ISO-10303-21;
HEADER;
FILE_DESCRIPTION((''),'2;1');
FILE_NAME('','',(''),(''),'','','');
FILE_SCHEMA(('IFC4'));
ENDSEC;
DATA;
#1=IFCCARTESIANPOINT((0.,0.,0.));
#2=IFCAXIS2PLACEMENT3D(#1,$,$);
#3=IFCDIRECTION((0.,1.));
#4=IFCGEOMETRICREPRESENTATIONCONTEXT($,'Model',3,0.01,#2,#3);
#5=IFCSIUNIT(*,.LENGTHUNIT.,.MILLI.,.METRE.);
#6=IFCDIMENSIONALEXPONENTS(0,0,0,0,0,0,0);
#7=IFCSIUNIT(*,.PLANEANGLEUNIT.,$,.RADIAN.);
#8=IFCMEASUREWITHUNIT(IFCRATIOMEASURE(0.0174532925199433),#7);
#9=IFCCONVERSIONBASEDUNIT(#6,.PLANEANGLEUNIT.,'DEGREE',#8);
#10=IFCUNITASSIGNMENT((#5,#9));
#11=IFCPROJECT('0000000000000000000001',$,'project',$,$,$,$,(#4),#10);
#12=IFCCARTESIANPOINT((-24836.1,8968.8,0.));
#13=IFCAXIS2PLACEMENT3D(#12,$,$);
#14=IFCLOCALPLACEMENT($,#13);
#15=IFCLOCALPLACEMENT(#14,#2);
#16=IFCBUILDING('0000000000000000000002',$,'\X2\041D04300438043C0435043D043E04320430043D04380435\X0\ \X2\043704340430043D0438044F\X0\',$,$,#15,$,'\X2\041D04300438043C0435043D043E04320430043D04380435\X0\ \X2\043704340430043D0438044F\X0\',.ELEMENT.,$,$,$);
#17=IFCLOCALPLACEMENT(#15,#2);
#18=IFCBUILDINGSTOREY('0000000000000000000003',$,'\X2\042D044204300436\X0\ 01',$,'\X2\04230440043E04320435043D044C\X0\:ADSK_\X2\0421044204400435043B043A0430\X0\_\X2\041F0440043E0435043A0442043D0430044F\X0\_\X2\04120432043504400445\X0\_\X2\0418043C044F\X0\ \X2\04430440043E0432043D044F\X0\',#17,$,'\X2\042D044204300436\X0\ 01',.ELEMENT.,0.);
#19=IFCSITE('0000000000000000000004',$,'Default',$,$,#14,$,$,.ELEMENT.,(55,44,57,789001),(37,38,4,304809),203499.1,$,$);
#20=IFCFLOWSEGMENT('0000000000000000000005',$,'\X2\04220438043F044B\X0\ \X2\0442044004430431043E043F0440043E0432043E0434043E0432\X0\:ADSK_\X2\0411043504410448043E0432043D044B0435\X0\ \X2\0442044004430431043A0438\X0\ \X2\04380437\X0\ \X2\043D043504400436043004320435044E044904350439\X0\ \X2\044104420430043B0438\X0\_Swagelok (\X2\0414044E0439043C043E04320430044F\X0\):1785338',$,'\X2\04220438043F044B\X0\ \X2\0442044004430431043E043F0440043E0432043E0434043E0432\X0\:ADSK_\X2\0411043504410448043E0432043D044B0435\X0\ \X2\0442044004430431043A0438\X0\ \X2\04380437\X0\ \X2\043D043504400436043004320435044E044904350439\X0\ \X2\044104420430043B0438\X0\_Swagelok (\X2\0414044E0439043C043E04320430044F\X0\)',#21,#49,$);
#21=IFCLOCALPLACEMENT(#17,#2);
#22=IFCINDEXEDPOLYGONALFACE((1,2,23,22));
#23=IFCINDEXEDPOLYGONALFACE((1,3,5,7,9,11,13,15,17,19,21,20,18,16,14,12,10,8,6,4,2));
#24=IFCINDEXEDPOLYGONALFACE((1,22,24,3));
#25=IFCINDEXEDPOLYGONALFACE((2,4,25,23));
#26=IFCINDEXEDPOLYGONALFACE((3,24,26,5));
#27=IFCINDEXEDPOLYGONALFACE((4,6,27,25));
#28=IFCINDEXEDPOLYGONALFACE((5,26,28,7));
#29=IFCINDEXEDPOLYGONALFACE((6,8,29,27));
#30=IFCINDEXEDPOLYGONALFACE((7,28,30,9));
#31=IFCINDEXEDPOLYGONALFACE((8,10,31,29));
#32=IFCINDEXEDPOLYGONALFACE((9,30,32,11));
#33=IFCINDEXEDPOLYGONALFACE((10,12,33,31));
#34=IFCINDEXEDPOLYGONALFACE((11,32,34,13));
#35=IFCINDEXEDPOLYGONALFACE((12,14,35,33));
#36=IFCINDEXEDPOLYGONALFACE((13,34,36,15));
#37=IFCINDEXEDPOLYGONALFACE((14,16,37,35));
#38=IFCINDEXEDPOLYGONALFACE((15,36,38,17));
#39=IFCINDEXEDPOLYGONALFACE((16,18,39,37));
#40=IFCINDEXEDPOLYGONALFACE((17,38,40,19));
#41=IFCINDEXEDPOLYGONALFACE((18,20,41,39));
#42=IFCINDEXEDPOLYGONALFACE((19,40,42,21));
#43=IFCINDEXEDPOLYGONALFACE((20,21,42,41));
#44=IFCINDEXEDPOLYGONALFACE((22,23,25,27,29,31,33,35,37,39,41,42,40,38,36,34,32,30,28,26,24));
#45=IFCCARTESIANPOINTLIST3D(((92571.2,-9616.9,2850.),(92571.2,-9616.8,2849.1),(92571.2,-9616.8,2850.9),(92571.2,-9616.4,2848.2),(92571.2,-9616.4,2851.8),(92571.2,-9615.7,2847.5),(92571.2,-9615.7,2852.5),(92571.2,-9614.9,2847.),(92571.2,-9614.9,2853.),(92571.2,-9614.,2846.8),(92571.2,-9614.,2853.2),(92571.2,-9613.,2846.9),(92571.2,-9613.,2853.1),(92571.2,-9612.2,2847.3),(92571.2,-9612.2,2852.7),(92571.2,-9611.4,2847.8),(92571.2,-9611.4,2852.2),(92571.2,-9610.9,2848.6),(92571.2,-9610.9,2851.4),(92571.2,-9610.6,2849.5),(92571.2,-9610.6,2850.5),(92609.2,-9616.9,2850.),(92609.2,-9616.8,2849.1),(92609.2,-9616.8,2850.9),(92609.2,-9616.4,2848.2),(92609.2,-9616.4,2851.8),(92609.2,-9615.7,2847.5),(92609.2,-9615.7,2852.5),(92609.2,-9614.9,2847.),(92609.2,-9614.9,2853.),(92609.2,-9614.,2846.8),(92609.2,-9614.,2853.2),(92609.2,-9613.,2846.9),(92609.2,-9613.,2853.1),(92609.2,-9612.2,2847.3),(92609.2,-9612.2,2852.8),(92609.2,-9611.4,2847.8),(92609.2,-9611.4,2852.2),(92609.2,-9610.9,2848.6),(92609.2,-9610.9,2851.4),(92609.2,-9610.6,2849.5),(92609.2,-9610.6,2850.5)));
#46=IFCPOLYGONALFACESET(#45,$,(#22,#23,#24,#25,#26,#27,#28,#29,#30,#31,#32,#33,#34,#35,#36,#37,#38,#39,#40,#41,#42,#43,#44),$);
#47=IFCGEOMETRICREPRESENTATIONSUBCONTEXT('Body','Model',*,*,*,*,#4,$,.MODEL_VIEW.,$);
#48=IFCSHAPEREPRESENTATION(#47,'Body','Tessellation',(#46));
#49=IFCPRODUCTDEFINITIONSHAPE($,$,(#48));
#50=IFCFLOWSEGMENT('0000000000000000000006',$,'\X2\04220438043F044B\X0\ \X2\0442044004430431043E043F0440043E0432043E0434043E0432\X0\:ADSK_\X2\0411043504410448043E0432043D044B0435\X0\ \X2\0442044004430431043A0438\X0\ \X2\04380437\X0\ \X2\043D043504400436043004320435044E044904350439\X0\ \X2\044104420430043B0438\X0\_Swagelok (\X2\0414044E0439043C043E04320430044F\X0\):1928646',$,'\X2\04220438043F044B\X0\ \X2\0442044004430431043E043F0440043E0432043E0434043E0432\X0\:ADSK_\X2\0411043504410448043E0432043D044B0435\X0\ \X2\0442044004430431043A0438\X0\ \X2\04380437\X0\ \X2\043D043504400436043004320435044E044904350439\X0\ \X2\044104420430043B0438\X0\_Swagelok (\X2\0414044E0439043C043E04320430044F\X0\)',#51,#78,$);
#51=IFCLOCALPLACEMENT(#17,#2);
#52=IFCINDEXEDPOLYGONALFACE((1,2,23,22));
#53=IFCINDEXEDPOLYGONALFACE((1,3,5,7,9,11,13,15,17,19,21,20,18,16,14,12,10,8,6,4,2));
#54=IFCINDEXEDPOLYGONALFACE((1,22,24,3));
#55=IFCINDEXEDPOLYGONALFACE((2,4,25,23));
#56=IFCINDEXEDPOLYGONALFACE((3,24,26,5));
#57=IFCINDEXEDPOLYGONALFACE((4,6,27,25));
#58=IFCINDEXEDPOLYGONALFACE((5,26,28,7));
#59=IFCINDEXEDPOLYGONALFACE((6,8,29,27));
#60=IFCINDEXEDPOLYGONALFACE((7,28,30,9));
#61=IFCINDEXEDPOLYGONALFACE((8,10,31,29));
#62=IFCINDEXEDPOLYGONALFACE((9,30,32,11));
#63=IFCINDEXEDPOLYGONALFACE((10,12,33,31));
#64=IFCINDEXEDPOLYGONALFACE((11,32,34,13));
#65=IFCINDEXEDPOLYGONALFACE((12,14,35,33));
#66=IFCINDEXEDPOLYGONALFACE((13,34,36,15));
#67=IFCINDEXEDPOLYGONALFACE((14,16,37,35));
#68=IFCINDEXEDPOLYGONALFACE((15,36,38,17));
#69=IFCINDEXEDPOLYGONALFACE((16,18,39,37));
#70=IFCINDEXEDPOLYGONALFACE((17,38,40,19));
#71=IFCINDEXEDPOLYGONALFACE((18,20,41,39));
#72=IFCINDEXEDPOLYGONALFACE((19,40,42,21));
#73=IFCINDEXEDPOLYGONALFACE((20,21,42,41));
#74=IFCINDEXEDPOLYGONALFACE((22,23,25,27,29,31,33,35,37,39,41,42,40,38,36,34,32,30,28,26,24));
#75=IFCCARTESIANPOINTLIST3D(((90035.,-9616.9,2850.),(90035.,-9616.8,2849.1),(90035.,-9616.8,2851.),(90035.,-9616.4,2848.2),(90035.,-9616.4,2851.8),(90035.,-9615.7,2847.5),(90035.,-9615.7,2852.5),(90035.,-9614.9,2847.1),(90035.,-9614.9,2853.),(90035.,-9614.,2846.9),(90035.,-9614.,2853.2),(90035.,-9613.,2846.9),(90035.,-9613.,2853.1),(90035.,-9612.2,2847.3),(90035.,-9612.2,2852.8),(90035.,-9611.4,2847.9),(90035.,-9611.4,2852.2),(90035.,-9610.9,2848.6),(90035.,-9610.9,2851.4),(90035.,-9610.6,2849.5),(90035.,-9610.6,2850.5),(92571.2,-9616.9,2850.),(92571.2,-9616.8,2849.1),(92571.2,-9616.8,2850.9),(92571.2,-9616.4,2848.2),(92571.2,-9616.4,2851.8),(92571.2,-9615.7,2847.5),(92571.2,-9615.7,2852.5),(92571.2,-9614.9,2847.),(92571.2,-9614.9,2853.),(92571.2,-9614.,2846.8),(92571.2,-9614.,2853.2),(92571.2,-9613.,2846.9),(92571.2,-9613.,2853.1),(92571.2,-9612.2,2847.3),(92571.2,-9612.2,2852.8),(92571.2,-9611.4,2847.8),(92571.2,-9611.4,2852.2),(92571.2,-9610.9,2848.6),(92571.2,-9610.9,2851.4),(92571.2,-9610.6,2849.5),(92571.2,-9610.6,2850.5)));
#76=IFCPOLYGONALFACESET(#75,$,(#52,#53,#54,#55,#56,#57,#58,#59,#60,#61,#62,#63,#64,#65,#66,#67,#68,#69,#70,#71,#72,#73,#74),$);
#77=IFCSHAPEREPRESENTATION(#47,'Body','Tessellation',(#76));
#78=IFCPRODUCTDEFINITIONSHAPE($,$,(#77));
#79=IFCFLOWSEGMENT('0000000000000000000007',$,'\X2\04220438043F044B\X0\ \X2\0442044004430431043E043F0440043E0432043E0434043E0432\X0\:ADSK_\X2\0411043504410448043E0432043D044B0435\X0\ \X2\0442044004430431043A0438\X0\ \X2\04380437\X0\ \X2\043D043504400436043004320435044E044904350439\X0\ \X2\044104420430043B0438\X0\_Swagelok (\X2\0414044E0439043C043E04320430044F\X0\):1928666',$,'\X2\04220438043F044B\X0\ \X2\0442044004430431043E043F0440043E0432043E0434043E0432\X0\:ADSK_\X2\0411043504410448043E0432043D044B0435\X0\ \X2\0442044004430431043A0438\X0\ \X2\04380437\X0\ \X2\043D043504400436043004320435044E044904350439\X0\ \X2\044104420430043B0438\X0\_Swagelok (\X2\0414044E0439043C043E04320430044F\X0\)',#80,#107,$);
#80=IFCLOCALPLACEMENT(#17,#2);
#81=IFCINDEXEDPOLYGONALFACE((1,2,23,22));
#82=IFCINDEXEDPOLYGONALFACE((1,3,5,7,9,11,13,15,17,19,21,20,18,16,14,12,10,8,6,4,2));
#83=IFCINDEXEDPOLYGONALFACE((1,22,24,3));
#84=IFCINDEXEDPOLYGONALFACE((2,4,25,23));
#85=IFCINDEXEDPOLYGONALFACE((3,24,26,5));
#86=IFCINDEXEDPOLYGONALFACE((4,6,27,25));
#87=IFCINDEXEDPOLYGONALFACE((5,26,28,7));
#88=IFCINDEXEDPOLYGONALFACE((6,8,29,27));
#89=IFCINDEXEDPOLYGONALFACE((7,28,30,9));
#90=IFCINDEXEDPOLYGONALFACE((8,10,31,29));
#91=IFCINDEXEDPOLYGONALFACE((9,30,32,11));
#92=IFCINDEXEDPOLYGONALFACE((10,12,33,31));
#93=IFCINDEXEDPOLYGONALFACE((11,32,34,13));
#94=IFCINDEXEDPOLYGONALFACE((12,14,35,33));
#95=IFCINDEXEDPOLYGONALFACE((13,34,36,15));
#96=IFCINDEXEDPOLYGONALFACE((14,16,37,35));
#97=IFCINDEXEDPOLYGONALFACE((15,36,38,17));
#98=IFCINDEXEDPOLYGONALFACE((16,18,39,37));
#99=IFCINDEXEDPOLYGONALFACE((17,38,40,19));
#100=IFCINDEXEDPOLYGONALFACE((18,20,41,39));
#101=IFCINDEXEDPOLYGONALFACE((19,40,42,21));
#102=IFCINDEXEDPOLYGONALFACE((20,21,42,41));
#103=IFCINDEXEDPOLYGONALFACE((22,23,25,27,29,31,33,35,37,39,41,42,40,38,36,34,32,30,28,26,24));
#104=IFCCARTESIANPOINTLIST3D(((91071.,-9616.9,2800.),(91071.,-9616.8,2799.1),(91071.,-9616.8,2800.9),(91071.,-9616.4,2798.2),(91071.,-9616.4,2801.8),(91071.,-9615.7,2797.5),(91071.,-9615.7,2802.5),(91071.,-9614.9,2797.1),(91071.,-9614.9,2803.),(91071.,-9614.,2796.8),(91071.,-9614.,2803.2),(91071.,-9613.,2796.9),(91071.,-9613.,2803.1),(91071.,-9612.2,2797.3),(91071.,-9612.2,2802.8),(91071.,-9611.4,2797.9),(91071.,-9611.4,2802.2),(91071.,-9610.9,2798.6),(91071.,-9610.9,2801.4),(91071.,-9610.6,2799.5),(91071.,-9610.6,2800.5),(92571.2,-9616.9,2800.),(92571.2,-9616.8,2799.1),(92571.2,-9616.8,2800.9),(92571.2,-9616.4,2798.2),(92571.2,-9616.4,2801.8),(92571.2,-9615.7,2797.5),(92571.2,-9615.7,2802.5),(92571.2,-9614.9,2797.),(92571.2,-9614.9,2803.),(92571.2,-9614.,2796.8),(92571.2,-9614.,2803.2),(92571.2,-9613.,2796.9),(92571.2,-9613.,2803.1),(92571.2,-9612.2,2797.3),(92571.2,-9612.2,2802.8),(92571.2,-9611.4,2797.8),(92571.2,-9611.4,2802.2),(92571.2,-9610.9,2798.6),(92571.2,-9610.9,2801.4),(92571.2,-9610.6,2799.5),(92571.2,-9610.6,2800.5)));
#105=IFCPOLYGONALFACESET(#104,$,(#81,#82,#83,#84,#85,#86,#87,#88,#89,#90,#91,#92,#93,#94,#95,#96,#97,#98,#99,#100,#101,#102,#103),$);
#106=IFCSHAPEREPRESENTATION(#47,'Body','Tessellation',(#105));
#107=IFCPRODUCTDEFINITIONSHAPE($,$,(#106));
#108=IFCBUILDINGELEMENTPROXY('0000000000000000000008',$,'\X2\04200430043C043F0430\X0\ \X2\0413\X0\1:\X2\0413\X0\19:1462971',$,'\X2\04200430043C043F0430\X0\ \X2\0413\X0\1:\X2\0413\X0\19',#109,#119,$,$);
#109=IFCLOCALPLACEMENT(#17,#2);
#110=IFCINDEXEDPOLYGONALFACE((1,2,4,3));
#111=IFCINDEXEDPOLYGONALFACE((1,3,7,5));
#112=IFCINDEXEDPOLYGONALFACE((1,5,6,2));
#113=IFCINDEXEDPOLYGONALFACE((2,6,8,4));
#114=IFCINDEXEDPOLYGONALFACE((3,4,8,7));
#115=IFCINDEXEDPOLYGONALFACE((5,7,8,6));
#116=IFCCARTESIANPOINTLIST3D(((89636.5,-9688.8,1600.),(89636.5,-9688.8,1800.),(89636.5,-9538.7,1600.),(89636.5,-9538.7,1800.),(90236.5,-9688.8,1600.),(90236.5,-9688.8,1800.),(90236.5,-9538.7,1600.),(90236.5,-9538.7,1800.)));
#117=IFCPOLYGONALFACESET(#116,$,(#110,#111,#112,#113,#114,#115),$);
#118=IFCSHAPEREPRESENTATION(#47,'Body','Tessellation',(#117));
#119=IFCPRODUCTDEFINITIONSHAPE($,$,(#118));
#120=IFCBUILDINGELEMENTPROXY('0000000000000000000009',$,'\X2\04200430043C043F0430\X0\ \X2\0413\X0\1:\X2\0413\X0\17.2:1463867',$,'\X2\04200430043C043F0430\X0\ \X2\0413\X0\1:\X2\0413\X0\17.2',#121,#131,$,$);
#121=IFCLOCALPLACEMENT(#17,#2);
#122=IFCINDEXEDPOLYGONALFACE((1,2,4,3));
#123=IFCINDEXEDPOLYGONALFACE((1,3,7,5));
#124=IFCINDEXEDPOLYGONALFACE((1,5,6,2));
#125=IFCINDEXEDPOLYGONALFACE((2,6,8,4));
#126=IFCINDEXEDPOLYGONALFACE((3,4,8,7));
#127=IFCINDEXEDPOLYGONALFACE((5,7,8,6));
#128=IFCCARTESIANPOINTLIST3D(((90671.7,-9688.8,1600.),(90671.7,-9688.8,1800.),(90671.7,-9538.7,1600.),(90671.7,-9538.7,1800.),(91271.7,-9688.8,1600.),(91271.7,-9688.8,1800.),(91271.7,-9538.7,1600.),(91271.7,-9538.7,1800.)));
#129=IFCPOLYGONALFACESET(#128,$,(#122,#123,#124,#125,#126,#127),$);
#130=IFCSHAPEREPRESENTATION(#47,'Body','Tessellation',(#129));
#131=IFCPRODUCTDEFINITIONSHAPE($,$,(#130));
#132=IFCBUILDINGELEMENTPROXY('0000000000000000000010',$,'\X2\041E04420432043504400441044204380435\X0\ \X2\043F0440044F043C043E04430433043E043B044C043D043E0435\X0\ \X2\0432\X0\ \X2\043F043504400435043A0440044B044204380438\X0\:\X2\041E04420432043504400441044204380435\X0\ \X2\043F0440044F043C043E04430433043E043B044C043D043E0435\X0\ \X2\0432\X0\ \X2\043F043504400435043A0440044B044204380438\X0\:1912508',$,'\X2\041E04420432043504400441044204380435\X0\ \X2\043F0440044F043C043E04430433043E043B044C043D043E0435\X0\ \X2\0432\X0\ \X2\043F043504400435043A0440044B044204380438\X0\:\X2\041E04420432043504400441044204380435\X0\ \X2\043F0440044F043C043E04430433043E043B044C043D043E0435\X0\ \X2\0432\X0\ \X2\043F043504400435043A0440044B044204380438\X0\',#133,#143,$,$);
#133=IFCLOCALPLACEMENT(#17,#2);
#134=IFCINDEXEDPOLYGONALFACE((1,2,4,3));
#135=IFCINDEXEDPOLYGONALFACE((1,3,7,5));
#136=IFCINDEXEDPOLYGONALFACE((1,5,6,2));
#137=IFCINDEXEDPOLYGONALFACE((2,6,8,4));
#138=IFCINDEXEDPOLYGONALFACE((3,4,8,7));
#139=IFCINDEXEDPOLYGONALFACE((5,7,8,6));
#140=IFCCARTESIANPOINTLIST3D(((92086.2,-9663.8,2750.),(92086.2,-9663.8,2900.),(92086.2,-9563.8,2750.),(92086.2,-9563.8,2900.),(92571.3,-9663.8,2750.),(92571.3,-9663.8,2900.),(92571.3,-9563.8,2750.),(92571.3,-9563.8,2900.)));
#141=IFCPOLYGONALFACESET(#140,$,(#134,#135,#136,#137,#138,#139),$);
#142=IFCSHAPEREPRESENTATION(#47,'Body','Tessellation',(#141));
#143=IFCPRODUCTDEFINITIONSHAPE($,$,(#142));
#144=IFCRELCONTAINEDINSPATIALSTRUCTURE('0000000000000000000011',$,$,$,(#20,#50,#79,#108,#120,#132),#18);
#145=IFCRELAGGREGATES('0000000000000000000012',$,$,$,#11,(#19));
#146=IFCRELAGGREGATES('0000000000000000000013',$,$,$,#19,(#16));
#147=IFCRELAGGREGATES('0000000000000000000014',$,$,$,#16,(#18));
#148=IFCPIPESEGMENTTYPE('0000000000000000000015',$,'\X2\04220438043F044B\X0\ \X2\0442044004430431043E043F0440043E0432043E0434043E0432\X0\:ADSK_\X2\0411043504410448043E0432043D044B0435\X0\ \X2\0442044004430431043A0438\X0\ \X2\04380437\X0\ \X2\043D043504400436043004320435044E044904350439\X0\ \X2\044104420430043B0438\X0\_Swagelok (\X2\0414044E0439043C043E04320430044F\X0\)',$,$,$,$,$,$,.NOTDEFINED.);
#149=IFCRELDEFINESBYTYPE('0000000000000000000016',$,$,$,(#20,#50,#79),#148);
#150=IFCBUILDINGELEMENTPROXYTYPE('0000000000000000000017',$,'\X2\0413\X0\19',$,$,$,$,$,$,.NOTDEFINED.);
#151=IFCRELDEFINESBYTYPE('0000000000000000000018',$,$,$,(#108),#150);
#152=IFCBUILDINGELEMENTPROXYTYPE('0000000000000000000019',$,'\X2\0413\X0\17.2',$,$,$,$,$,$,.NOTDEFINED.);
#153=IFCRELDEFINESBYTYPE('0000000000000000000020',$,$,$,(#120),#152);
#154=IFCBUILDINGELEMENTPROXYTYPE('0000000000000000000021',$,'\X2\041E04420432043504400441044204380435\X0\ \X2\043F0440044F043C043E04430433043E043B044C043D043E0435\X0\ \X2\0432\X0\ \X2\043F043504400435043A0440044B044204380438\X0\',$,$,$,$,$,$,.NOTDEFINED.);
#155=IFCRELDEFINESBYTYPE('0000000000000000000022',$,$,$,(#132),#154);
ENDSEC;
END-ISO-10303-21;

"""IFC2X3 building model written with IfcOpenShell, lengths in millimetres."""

from ifc_helpers import new_model, entity, si_unit, converted_unit, direction, frame, origin, origin_2d_with_axis, place, context, subcontext, project, spatial, rectangle, circle, extrude, type_object, element, save


model = new_model("IFC2X3")

# Units and contexts
model_context = context("Model", 3, precision=0.01, world=origin(), true_north=direction((0.0, 1.0)))
body_context = subcontext(model_context, "Body", "Model", "MODEL_VIEW")
ifc_project = project(units=[si_unit("LENGTHUNIT", "METRE", prefix="MILLI"), converted_unit("PLANEANGLEUNIT", "DEGREE", entity("IfcRatioMeasure", 0.0174532925199433), si_unit("PLANEANGLEUNIT", "RADIAN"), dimensions=[0, 0, 0, 0, 0, 0, 0])], contexts=[model_context])

# Site, building, storey
site_placement = place(None, frame((-24836.1, 8968.8, 0.0)))
site = spatial("IfcSite", under=ifc_project, at=site_placement, Name="Default", CompositionType="ELEMENT", RefLatitude=(55, 44, 57, 789001), RefLongitude=(37, 38, 4, 304809), RefElevation=203499.1)
building_placement = place(site_placement, origin())
building = spatial("IfcBuilding", under=site, at=building_placement, Name="Наименование здания", LongName="Наименование здания", CompositionType="ELEMENT")
storey_placement = place(building_placement, origin())
storey = spatial("IfcBuildingStorey", under=building, at=storey_placement, Name="Этаж 01", ObjectType="Уровень:ADSK_Стрелка_Проектная_Вверх_Имя уровня", LongName="Этаж 01", CompositionType="ELEMENT", Elevation=0.0)

# Flow segments
pipe_segment_type_1 = type_object("IfcPipeSegmentType", Name="Типы трубопроводов:ADSK_Бесшовные трубки из нержавеющей стали_Swagelok (Дюймовая)", PredefinedType="NOTDEFINED")
flow_segment_1_placement = place(storey_placement, frame((92571.2, -9618.5, 2845.2)))
element("IfcFlowSegment", 1, at=flow_segment_1_placement, inside=storey, type_object=pipe_segment_type_1, Name="Типы трубопроводов:ADSK_Бесшовные трубки из нержавеющей стали_Swagelok (Дюймовая):1785338", ObjectType="Типы трубопроводов:ADSK_Бесшовные трубки из нержавеющей стали_Swagelok (Дюймовая)", context=body_context, shape_type="SweptSolid", body=[
    extrude(circle(Radius=3.2, at=origin_2d_with_axis()), frame((0.0, 4.8, 4.8), z_axis=(1.0, 0.0, 0.000087), x_axis=(0.0, -1.0, 0.0)), (0.0, 0.0, 1.0), 38.0),
])
flow_segment_2_placement = place(storey_placement, frame((90035.0, -9618.5, 2845.2)))
element("IfcFlowSegment", 2, at=flow_segment_2_placement, inside=storey, type_object=pipe_segment_type_1, Name="Типы трубопроводов:ADSK_Бесшовные трубки из нержавеющей стали_Swagelok (Дюймовая):1928646", ObjectType="Типы трубопроводов:ADSK_Бесшовные трубки из нержавеющей стали_Swagelok (Дюймовая)", context=body_context, shape_type="SweptSolid", body=[
    extrude(circle(Radius=3.2, at=origin_2d_with_axis()), frame((0.0, 4.8, 4.8), z_axis=(1.0, 0.0, -0.000006), x_axis=(0.0, -1.0, 0.0)), (0.0, 0.0, 1.0), 2536.2),
])
flow_segment_3_placement = place(storey_placement, frame((91071.0, -9618.5, 2795.2)))
element("IfcFlowSegment", 3, at=flow_segment_3_placement, inside=storey, type_object=pipe_segment_type_1, Name="Типы трубопроводов:ADSK_Бесшовные трубки из нержавеющей стали_Swagelok (Дюймовая):1928666", ObjectType="Типы трубопроводов:ADSK_Бесшовные трубки из нержавеющей стали_Swagelok (Дюймовая)", context=body_context, shape_type="SweptSolid", body=[
    extrude(circle(Radius=3.2, at=origin_2d_with_axis()), frame((0.0, 4.8, 4.8), z_axis=(1.0, 0.0, -0.000006), x_axis=(0.0, -1.0, 0.0)), (0.0, 0.0, 1.0), 1500.3),
])

# Building element proxies
building_element_proxy_type_1 = type_object("IfcBuildingElementProxyType", Name="Г19", PredefinedType="NOTDEFINED")
proxy_1_placement = place(storey_placement, frame((89636.5, -9688.8, 1600.0)))
element("IfcBuildingElementProxy", 4, at=proxy_1_placement, inside=storey, type_object=building_element_proxy_type_1, Name="Рампа Г1:Г19:1462971", ObjectType="Рампа Г1:Г19", context=body_context, shape_type="SweptSolid", body=[
    extrude(rectangle(XDim=150.0, YDim=600.0, at=origin_2d_with_axis()), frame((300.0, 75.0, 0.0), z_axis=(0.0, 0.0, 1.0), x_axis=(0.0, 1.0, 0.0)), (0.0, 0.0, 1.0), 200.0),
])
building_element_proxy_type_2 = type_object("IfcBuildingElementProxyType", Name="Г17.2", PredefinedType="NOTDEFINED")
proxy_2_placement = place(storey_placement, frame((90671.7, -9688.8, 1600.0)))
element("IfcBuildingElementProxy", 5, at=proxy_2_placement, inside=storey, type_object=building_element_proxy_type_2, Name="Рампа Г1:Г17.2:1463867", ObjectType="Рампа Г1:Г17.2", context=body_context, shape_type="SweptSolid", body=[
    extrude(rectangle(XDim=150.0, YDim=600.0, at=origin_2d_with_axis()), frame((300.0, 75.0, 0.0), z_axis=(0.0, 0.0, 1.0), x_axis=(0.0, 1.0, 0.0)), (0.0, 0.0, 1.0), 200.0),
])
building_element_proxy_type_3 = type_object("IfcBuildingElementProxyType", Name="Отверстие прямоугольное в перекрытии", PredefinedType="NOTDEFINED")
proxy_3_placement = place(storey_placement, frame((92086.2, -9663.8, 2750.0)))
element("IfcBuildingElementProxy", 6, at=proxy_3_placement, inside=storey, type_object=building_element_proxy_type_3, Name="Отверстие прямоугольное в перекрытии:Отверстие прямоугольное в перекрытии:1912508", ObjectType="Отверстие прямоугольное в перекрытии:Отверстие прямоугольное в перекрытии", context=body_context, shape_type="SweptSolid", body=[
    extrude(rectangle(XDim=485.0, YDim=100.0, at=origin_2d_with_axis()), frame((242.5, 50.0, 0.0), z_axis=(0.0, 0.0, 1.0), x_axis=(-1.0, 0.0, 0.0)), (0.0, 0.0, 1.0), 150.0),
])

save(model, "model.ifc")
